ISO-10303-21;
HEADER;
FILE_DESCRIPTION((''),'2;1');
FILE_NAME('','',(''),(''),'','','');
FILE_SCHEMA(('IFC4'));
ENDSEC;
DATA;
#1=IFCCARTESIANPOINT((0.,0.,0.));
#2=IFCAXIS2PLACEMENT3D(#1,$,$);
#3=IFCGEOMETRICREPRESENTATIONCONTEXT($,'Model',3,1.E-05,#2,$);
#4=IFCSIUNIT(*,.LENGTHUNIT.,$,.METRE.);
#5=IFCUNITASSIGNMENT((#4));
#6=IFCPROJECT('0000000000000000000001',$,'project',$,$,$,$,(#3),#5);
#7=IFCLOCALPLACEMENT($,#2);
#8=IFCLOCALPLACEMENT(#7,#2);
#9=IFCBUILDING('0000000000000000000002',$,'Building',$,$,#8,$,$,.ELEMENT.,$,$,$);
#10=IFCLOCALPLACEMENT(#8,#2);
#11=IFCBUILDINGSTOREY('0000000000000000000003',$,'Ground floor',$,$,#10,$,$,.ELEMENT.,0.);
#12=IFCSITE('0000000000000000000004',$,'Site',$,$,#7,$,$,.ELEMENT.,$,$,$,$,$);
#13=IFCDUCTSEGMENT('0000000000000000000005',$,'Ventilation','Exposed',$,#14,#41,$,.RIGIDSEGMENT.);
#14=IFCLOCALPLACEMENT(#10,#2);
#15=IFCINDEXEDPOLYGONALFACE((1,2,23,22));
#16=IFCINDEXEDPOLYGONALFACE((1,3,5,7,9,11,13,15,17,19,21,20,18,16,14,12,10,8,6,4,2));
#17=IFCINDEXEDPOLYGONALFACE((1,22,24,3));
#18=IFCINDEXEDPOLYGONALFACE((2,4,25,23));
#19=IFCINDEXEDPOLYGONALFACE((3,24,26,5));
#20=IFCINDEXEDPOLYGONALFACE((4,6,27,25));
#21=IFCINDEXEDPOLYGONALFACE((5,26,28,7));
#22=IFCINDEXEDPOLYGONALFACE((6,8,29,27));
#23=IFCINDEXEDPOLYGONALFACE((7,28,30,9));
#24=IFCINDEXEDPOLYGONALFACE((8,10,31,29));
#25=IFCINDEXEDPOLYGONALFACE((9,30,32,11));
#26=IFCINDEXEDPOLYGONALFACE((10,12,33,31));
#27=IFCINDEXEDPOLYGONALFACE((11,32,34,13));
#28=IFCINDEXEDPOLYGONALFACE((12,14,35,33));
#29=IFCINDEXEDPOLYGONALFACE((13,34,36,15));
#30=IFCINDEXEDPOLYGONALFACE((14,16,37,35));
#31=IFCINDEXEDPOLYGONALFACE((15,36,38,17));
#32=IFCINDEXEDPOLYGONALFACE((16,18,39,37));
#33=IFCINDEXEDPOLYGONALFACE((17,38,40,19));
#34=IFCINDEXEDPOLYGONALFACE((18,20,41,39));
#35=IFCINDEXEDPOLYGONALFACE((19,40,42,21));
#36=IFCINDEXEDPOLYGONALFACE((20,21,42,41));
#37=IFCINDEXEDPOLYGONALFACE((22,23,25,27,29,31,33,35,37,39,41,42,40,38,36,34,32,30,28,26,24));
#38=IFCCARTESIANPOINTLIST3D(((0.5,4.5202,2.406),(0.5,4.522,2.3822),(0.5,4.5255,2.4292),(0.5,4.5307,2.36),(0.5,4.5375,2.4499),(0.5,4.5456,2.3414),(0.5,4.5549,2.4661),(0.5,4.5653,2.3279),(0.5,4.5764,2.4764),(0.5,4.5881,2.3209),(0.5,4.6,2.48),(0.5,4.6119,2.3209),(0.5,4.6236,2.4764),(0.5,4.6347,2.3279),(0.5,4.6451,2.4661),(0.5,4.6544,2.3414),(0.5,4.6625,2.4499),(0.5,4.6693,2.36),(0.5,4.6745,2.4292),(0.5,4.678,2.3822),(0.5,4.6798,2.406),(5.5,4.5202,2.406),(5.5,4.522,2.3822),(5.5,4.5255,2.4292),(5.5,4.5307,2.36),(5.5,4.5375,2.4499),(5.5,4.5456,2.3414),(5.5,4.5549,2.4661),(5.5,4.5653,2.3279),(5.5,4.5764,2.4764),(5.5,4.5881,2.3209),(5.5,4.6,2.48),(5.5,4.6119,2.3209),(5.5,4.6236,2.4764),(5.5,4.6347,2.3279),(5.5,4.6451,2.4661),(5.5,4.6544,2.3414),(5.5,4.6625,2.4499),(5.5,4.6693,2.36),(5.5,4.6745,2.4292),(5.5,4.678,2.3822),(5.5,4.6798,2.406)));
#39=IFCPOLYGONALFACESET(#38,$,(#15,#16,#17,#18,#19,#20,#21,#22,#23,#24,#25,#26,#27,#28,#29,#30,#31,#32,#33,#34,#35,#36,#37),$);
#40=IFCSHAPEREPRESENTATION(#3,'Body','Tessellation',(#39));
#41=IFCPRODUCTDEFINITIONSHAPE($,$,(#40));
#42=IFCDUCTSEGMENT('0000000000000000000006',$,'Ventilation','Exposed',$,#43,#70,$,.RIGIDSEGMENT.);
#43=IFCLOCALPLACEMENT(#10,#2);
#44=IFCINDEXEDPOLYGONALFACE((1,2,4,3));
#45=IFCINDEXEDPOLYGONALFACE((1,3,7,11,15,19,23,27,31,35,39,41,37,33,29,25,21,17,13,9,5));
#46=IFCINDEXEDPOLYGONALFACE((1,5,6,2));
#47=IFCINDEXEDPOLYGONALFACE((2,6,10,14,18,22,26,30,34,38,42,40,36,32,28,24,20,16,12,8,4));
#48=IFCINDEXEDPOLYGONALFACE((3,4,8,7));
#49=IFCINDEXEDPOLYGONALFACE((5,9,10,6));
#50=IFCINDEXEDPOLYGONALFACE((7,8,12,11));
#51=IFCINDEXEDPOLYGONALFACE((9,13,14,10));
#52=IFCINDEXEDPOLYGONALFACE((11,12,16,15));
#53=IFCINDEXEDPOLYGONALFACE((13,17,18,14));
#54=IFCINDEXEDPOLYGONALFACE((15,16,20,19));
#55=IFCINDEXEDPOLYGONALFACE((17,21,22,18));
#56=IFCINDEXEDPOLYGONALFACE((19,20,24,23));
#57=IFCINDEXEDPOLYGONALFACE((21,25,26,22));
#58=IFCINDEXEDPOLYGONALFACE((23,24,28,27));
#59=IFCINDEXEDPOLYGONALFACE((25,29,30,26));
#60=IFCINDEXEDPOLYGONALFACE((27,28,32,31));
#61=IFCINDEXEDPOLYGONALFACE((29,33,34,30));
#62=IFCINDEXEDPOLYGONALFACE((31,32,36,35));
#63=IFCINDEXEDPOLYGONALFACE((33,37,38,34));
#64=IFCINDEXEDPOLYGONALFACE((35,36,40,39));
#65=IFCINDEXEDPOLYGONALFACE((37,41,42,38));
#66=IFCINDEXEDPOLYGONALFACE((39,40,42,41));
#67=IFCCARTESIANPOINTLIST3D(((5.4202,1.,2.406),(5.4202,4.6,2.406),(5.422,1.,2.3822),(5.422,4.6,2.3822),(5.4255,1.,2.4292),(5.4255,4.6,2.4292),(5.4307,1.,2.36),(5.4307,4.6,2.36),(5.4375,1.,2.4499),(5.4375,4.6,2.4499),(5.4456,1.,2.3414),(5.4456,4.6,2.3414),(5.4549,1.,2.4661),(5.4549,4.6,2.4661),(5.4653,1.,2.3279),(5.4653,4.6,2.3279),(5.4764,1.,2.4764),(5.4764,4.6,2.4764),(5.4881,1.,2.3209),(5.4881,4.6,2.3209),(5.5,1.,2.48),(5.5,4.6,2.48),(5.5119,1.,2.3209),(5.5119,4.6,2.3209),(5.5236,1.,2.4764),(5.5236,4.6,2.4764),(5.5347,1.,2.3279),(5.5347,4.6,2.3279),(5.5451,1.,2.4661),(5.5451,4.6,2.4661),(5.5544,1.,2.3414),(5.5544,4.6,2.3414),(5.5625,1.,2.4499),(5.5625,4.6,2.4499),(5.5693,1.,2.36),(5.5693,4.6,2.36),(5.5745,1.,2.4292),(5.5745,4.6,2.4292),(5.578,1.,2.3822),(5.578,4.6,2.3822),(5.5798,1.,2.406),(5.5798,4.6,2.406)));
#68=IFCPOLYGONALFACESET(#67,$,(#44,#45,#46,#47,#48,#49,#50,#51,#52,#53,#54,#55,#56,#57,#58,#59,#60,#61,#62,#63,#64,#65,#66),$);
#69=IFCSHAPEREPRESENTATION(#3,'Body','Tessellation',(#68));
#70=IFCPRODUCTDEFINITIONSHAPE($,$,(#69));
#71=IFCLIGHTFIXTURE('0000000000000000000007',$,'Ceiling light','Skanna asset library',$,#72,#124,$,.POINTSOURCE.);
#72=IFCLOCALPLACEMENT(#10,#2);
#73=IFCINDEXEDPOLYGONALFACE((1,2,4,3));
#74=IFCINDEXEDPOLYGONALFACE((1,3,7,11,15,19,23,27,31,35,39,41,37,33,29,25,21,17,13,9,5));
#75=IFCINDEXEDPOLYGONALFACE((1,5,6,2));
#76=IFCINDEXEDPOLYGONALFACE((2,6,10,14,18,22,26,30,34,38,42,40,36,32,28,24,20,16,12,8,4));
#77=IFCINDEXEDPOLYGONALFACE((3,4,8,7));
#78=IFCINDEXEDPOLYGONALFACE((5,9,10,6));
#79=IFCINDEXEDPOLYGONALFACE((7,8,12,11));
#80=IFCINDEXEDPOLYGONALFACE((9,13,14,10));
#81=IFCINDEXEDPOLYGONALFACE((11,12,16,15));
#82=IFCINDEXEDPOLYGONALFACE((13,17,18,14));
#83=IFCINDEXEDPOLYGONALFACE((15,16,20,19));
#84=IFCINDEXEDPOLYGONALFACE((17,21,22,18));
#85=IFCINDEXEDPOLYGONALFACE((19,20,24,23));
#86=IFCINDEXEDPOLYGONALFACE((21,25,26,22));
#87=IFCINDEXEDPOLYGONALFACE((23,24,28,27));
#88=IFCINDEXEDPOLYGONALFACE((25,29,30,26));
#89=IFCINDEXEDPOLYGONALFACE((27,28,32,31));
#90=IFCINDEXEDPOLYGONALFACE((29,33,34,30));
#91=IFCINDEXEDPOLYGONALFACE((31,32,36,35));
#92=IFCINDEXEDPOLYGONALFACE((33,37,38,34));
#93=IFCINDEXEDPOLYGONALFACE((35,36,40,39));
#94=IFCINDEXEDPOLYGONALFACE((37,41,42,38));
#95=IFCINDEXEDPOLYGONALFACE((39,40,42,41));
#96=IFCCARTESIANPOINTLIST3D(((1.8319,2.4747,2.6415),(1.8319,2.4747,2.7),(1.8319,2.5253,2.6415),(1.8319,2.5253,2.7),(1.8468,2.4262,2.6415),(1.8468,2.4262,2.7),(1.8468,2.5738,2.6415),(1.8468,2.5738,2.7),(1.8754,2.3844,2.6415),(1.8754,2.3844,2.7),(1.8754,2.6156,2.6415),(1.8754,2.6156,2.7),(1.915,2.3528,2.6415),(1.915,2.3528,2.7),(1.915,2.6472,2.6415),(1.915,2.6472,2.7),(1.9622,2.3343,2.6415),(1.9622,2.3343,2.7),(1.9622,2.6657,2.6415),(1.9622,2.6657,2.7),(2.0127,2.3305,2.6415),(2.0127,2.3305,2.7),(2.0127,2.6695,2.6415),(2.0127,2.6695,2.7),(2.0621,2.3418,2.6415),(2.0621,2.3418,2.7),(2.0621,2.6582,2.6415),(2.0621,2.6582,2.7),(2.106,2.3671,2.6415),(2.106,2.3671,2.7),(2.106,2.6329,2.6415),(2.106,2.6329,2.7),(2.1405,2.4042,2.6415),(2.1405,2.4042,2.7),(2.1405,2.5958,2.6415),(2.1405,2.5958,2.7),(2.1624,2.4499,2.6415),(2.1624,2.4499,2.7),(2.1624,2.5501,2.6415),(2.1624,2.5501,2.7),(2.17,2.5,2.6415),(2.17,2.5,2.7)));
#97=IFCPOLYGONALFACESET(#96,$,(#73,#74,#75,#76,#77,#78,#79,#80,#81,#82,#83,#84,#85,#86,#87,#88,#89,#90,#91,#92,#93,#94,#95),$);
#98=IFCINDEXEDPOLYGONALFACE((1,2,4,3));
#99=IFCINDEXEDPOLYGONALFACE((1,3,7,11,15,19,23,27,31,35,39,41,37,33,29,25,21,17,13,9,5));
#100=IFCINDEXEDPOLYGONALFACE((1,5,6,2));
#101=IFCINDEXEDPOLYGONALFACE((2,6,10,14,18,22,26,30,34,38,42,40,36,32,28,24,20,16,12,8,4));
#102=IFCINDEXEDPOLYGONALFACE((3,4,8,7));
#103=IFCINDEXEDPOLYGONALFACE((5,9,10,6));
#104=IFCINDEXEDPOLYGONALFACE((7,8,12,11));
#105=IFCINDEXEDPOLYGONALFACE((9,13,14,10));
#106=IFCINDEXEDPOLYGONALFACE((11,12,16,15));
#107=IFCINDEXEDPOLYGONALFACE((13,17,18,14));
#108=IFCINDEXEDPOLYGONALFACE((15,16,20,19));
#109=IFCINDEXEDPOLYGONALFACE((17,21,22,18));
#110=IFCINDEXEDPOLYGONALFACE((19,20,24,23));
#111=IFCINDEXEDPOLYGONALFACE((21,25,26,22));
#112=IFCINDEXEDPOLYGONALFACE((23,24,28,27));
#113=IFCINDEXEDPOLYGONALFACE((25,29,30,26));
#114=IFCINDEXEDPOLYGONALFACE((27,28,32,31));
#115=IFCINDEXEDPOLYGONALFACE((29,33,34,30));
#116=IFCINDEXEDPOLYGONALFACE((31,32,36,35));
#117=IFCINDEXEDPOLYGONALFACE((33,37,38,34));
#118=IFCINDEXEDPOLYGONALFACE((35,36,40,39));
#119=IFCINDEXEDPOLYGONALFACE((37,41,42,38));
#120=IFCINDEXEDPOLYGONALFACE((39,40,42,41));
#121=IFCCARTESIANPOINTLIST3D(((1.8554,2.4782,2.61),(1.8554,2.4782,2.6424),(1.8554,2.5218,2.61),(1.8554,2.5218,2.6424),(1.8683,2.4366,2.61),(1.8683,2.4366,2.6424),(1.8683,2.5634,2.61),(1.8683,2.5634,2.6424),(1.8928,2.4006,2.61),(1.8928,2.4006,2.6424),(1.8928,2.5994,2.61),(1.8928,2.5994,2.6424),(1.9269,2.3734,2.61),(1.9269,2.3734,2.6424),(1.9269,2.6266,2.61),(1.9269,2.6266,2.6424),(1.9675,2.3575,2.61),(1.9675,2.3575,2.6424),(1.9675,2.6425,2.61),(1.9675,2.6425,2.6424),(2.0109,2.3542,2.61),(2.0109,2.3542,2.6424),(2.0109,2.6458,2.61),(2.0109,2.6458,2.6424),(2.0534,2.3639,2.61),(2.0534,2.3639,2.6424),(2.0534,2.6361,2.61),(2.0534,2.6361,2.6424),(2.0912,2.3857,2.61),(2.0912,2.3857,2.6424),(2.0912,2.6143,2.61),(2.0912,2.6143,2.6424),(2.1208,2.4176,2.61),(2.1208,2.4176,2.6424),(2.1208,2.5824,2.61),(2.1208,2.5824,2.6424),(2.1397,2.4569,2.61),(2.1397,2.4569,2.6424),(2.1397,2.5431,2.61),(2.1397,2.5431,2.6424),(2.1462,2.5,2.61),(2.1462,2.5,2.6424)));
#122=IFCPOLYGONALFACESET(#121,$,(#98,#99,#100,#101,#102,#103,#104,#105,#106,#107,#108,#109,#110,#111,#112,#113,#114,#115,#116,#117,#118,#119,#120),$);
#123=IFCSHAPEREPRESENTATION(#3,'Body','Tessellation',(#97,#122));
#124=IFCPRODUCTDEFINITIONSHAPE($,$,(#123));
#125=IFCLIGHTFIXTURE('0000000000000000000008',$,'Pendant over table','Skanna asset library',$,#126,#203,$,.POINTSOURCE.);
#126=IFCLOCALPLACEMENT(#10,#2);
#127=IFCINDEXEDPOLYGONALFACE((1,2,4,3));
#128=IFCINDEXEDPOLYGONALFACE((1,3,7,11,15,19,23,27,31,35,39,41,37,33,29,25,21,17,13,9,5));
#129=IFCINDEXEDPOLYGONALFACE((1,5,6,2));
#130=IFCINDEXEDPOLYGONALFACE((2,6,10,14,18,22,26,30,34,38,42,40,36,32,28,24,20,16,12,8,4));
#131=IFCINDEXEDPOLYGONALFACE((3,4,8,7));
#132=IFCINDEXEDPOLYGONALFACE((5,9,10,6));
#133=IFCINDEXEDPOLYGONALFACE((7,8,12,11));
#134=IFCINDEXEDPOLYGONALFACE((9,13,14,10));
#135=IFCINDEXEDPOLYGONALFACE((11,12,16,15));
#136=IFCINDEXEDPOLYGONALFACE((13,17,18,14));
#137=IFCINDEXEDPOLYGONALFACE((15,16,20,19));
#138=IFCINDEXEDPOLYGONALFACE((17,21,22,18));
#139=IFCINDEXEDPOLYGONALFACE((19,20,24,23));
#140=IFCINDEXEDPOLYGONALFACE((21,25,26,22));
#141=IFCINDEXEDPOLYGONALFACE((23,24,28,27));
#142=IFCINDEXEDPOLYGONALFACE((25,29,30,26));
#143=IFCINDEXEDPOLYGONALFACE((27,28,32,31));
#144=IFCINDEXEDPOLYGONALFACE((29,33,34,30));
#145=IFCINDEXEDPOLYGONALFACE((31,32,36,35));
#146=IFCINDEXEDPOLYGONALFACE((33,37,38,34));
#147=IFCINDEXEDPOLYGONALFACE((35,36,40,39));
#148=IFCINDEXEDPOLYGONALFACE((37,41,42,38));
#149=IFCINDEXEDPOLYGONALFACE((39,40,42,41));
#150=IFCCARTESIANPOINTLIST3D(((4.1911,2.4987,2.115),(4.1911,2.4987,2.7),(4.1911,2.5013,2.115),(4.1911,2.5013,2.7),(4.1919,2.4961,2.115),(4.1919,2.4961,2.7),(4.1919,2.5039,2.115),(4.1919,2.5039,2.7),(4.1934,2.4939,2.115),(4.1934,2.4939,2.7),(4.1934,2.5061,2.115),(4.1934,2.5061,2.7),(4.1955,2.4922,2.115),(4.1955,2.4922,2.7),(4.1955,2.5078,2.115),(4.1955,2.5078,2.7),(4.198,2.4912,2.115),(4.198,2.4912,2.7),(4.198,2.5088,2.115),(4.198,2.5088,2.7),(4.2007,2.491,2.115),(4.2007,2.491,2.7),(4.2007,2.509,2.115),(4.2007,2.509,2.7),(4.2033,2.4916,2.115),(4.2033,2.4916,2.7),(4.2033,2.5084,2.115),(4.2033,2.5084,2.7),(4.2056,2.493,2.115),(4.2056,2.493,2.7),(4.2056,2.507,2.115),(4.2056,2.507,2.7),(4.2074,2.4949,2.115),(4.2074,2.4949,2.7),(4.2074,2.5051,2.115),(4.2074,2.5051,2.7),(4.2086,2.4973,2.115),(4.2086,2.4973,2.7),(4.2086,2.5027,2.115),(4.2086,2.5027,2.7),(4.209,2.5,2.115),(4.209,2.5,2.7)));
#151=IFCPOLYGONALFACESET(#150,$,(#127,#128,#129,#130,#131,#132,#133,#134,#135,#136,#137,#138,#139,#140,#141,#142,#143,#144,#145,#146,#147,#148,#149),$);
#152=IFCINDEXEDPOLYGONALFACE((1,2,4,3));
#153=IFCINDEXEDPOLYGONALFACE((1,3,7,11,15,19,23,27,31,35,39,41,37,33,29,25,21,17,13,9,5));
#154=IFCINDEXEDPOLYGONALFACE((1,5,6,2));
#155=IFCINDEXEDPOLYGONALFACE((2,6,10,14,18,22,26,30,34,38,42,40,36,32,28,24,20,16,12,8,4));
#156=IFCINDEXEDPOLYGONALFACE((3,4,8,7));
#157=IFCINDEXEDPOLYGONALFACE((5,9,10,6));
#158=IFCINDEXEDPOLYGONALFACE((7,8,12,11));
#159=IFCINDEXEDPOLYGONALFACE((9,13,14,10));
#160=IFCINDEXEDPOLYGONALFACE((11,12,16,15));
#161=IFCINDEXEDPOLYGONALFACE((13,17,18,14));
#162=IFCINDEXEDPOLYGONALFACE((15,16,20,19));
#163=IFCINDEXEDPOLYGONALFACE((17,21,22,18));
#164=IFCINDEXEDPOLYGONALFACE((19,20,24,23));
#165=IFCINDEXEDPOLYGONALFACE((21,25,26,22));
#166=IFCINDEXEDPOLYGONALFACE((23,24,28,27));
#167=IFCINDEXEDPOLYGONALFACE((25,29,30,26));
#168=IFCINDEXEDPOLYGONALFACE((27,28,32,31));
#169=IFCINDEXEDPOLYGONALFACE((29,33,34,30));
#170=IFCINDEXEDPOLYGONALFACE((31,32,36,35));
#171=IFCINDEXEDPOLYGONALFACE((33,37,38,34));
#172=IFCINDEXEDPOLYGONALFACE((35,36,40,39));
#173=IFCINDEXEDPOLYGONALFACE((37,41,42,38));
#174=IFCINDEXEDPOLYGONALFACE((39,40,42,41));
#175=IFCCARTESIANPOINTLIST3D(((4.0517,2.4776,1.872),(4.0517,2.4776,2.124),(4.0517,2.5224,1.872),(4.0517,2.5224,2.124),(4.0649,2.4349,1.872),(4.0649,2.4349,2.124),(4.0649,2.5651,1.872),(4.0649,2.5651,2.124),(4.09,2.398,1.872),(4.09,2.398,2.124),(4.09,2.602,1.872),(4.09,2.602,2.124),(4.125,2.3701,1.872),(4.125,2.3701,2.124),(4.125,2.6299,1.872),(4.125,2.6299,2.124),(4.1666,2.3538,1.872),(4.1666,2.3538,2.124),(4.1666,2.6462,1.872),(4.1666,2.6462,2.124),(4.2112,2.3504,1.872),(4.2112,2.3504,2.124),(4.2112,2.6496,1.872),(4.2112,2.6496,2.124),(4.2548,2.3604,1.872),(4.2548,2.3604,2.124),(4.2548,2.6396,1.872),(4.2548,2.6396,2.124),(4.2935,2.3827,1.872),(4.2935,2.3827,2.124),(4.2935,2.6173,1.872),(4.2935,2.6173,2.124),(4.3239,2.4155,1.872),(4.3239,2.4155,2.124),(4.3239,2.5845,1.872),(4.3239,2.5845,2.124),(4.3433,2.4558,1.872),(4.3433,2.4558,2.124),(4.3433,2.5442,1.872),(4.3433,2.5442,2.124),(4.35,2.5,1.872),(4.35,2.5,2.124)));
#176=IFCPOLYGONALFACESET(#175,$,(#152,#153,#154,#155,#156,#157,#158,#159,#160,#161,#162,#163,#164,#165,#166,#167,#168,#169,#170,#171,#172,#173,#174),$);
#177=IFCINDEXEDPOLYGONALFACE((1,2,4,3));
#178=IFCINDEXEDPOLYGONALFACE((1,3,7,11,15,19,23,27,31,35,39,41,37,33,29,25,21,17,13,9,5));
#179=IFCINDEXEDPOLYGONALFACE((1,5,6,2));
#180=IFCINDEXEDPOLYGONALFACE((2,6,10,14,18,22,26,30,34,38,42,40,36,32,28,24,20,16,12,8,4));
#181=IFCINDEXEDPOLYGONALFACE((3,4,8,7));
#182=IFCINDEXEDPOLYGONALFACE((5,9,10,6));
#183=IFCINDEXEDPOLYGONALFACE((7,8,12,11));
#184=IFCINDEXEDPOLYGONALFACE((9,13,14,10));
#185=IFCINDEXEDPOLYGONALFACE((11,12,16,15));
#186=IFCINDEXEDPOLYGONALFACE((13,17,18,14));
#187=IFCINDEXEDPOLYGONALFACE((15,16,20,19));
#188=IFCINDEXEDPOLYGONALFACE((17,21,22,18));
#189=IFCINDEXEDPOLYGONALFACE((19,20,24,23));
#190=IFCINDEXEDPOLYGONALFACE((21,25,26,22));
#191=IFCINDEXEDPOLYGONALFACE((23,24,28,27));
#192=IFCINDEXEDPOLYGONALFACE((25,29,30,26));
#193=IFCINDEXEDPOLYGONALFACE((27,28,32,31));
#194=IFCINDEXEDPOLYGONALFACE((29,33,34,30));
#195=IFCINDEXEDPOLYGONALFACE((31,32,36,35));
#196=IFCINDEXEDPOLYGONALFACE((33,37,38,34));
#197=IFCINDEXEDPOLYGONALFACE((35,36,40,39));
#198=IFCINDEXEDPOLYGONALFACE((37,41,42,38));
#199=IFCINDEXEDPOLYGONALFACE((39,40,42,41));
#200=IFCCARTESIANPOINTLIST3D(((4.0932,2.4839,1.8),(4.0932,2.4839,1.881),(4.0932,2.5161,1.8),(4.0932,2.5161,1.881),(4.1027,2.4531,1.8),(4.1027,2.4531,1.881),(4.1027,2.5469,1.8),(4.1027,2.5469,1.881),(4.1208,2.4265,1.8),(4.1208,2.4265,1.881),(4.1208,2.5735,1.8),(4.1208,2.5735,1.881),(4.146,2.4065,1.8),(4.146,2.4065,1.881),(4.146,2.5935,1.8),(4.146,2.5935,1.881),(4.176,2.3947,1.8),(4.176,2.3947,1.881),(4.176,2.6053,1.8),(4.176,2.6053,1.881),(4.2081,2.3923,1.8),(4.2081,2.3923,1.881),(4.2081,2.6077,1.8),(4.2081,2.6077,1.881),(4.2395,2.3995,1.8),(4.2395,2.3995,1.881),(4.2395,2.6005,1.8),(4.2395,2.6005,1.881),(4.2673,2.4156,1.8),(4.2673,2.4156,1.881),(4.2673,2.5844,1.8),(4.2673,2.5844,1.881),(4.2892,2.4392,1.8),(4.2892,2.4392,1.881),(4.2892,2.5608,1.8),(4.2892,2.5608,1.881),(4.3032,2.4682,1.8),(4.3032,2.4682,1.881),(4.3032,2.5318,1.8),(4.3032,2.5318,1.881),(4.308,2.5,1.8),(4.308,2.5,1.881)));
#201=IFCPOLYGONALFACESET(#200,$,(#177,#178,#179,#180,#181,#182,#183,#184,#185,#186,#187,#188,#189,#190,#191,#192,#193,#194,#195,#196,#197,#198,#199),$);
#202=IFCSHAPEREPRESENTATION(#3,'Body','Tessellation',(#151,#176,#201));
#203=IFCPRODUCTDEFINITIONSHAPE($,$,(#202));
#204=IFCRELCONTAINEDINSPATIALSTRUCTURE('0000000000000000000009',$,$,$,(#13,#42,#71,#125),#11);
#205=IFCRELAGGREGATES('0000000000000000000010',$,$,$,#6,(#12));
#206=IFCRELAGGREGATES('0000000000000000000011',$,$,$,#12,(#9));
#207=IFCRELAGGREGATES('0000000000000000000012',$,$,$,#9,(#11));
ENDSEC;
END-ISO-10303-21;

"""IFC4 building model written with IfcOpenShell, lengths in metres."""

from ifc_helpers import new_model, si_unit, frame, origin, origin_2d, place, context, project, spatial, circle, extrude, element, save


model = new_model("IFC4")

# Units and contexts
model_context = context("Model", 3, precision=1e-05, world=origin())
ifc_project = project(units=[si_unit("LENGTHUNIT", "METRE")], contexts=[model_context])

# Site, building, storey
site_placement = place(None, origin())
site = spatial("IfcSite", under=ifc_project, at=site_placement, Name="Site", CompositionType="ELEMENT")
building_placement = place(site_placement, origin())
building = spatial("IfcBuilding", under=site, at=building_placement, Name="Building", CompositionType="ELEMENT")
storey_placement = place(building_placement, origin())
storey = spatial("IfcBuildingStorey", under=building, at=storey_placement, Name="Ground floor", CompositionType="ELEMENT", Elevation=0.0)

# Duct segments
duct_segment_1_placement = place(storey_placement, frame((0.5, 4.6, 2.4), z_axis=(1.0, 0.0, 0.0), x_axis=(0.0, 0.0, 1.0)))
element("IfcDuctSegment", 1, at=duct_segment_1_placement, inside=storey, Name="Ventilation", Description="Exposed", PredefinedType="RIGIDSEGMENT", context=model_context, shape_type="SweptSolid", body=[
    extrude(circle(Radius=0.08, at=origin_2d()), origin(), (0.0, 0.0, 1.0), 5.0),
])
duct_segment_2_placement = place(storey_placement, frame((5.5, 4.6, 2.4), z_axis=(0.0, -1.0, 0.0), x_axis=(0.0, 0.0, 1.0)))
element("IfcDuctSegment", 2, at=duct_segment_2_placement, inside=storey, Name="Ventilation", Description="Exposed", PredefinedType="RIGIDSEGMENT", context=model_context, shape_type="SweptSolid", body=[
    extrude(circle(Radius=0.08, at=origin_2d()), origin(), (0.0, 0.0, 1.0), 3.6),
])

# Light fixtures
light_fixture_1_placement = place(storey_placement, frame((2.0, 2.5, 2.61), z_axis=(0.0, 0.0, 1.0), x_axis=(1.0, 0.0, 0.0)))
element("IfcLightFixture", 3, at=light_fixture_1_placement, inside=storey, Name="Ceiling light", Description="Skanna asset library", PredefinedType="POINTSOURCE", context=model_context, shape_type="SweptSolid", body=[
    extrude(circle(Radius=0.17, at=origin_2d()), frame((0.0, 0.0, 0.0315)), (0.0, 0.0, 1.0), 0.0585),
    extrude(circle(Radius=0.1462, at=origin_2d()), origin(), (0.0, 0.0, 1.0), 0.0324),
])
light_fixture_2_placement = place(storey_placement, frame((4.2, 2.5, 1.8), z_axis=(0.0, 0.0, 1.0), x_axis=(1.0, 0.0, 0.0)))
element("IfcLightFixture", 4, at=light_fixture_2_placement, inside=storey, Name="Pendant over table", Description="Skanna asset library", PredefinedType="POINTSOURCE", context=model_context, shape_type="SweptSolid", body=[
    extrude(circle(Radius=0.009, at=origin_2d()), frame((0.0, 0.0, 0.315)), (0.0, 0.0, 1.0), 0.585),
    extrude(circle(Radius=0.15, at=origin_2d()), frame((0.0, 0.0, 0.072)), (0.0, 0.0, 1.0), 0.252),
    extrude(circle(Radius=0.108, at=origin_2d()), origin(), (0.0, 0.0, 1.0), 0.081),
])

save(model, "model.ifc")
